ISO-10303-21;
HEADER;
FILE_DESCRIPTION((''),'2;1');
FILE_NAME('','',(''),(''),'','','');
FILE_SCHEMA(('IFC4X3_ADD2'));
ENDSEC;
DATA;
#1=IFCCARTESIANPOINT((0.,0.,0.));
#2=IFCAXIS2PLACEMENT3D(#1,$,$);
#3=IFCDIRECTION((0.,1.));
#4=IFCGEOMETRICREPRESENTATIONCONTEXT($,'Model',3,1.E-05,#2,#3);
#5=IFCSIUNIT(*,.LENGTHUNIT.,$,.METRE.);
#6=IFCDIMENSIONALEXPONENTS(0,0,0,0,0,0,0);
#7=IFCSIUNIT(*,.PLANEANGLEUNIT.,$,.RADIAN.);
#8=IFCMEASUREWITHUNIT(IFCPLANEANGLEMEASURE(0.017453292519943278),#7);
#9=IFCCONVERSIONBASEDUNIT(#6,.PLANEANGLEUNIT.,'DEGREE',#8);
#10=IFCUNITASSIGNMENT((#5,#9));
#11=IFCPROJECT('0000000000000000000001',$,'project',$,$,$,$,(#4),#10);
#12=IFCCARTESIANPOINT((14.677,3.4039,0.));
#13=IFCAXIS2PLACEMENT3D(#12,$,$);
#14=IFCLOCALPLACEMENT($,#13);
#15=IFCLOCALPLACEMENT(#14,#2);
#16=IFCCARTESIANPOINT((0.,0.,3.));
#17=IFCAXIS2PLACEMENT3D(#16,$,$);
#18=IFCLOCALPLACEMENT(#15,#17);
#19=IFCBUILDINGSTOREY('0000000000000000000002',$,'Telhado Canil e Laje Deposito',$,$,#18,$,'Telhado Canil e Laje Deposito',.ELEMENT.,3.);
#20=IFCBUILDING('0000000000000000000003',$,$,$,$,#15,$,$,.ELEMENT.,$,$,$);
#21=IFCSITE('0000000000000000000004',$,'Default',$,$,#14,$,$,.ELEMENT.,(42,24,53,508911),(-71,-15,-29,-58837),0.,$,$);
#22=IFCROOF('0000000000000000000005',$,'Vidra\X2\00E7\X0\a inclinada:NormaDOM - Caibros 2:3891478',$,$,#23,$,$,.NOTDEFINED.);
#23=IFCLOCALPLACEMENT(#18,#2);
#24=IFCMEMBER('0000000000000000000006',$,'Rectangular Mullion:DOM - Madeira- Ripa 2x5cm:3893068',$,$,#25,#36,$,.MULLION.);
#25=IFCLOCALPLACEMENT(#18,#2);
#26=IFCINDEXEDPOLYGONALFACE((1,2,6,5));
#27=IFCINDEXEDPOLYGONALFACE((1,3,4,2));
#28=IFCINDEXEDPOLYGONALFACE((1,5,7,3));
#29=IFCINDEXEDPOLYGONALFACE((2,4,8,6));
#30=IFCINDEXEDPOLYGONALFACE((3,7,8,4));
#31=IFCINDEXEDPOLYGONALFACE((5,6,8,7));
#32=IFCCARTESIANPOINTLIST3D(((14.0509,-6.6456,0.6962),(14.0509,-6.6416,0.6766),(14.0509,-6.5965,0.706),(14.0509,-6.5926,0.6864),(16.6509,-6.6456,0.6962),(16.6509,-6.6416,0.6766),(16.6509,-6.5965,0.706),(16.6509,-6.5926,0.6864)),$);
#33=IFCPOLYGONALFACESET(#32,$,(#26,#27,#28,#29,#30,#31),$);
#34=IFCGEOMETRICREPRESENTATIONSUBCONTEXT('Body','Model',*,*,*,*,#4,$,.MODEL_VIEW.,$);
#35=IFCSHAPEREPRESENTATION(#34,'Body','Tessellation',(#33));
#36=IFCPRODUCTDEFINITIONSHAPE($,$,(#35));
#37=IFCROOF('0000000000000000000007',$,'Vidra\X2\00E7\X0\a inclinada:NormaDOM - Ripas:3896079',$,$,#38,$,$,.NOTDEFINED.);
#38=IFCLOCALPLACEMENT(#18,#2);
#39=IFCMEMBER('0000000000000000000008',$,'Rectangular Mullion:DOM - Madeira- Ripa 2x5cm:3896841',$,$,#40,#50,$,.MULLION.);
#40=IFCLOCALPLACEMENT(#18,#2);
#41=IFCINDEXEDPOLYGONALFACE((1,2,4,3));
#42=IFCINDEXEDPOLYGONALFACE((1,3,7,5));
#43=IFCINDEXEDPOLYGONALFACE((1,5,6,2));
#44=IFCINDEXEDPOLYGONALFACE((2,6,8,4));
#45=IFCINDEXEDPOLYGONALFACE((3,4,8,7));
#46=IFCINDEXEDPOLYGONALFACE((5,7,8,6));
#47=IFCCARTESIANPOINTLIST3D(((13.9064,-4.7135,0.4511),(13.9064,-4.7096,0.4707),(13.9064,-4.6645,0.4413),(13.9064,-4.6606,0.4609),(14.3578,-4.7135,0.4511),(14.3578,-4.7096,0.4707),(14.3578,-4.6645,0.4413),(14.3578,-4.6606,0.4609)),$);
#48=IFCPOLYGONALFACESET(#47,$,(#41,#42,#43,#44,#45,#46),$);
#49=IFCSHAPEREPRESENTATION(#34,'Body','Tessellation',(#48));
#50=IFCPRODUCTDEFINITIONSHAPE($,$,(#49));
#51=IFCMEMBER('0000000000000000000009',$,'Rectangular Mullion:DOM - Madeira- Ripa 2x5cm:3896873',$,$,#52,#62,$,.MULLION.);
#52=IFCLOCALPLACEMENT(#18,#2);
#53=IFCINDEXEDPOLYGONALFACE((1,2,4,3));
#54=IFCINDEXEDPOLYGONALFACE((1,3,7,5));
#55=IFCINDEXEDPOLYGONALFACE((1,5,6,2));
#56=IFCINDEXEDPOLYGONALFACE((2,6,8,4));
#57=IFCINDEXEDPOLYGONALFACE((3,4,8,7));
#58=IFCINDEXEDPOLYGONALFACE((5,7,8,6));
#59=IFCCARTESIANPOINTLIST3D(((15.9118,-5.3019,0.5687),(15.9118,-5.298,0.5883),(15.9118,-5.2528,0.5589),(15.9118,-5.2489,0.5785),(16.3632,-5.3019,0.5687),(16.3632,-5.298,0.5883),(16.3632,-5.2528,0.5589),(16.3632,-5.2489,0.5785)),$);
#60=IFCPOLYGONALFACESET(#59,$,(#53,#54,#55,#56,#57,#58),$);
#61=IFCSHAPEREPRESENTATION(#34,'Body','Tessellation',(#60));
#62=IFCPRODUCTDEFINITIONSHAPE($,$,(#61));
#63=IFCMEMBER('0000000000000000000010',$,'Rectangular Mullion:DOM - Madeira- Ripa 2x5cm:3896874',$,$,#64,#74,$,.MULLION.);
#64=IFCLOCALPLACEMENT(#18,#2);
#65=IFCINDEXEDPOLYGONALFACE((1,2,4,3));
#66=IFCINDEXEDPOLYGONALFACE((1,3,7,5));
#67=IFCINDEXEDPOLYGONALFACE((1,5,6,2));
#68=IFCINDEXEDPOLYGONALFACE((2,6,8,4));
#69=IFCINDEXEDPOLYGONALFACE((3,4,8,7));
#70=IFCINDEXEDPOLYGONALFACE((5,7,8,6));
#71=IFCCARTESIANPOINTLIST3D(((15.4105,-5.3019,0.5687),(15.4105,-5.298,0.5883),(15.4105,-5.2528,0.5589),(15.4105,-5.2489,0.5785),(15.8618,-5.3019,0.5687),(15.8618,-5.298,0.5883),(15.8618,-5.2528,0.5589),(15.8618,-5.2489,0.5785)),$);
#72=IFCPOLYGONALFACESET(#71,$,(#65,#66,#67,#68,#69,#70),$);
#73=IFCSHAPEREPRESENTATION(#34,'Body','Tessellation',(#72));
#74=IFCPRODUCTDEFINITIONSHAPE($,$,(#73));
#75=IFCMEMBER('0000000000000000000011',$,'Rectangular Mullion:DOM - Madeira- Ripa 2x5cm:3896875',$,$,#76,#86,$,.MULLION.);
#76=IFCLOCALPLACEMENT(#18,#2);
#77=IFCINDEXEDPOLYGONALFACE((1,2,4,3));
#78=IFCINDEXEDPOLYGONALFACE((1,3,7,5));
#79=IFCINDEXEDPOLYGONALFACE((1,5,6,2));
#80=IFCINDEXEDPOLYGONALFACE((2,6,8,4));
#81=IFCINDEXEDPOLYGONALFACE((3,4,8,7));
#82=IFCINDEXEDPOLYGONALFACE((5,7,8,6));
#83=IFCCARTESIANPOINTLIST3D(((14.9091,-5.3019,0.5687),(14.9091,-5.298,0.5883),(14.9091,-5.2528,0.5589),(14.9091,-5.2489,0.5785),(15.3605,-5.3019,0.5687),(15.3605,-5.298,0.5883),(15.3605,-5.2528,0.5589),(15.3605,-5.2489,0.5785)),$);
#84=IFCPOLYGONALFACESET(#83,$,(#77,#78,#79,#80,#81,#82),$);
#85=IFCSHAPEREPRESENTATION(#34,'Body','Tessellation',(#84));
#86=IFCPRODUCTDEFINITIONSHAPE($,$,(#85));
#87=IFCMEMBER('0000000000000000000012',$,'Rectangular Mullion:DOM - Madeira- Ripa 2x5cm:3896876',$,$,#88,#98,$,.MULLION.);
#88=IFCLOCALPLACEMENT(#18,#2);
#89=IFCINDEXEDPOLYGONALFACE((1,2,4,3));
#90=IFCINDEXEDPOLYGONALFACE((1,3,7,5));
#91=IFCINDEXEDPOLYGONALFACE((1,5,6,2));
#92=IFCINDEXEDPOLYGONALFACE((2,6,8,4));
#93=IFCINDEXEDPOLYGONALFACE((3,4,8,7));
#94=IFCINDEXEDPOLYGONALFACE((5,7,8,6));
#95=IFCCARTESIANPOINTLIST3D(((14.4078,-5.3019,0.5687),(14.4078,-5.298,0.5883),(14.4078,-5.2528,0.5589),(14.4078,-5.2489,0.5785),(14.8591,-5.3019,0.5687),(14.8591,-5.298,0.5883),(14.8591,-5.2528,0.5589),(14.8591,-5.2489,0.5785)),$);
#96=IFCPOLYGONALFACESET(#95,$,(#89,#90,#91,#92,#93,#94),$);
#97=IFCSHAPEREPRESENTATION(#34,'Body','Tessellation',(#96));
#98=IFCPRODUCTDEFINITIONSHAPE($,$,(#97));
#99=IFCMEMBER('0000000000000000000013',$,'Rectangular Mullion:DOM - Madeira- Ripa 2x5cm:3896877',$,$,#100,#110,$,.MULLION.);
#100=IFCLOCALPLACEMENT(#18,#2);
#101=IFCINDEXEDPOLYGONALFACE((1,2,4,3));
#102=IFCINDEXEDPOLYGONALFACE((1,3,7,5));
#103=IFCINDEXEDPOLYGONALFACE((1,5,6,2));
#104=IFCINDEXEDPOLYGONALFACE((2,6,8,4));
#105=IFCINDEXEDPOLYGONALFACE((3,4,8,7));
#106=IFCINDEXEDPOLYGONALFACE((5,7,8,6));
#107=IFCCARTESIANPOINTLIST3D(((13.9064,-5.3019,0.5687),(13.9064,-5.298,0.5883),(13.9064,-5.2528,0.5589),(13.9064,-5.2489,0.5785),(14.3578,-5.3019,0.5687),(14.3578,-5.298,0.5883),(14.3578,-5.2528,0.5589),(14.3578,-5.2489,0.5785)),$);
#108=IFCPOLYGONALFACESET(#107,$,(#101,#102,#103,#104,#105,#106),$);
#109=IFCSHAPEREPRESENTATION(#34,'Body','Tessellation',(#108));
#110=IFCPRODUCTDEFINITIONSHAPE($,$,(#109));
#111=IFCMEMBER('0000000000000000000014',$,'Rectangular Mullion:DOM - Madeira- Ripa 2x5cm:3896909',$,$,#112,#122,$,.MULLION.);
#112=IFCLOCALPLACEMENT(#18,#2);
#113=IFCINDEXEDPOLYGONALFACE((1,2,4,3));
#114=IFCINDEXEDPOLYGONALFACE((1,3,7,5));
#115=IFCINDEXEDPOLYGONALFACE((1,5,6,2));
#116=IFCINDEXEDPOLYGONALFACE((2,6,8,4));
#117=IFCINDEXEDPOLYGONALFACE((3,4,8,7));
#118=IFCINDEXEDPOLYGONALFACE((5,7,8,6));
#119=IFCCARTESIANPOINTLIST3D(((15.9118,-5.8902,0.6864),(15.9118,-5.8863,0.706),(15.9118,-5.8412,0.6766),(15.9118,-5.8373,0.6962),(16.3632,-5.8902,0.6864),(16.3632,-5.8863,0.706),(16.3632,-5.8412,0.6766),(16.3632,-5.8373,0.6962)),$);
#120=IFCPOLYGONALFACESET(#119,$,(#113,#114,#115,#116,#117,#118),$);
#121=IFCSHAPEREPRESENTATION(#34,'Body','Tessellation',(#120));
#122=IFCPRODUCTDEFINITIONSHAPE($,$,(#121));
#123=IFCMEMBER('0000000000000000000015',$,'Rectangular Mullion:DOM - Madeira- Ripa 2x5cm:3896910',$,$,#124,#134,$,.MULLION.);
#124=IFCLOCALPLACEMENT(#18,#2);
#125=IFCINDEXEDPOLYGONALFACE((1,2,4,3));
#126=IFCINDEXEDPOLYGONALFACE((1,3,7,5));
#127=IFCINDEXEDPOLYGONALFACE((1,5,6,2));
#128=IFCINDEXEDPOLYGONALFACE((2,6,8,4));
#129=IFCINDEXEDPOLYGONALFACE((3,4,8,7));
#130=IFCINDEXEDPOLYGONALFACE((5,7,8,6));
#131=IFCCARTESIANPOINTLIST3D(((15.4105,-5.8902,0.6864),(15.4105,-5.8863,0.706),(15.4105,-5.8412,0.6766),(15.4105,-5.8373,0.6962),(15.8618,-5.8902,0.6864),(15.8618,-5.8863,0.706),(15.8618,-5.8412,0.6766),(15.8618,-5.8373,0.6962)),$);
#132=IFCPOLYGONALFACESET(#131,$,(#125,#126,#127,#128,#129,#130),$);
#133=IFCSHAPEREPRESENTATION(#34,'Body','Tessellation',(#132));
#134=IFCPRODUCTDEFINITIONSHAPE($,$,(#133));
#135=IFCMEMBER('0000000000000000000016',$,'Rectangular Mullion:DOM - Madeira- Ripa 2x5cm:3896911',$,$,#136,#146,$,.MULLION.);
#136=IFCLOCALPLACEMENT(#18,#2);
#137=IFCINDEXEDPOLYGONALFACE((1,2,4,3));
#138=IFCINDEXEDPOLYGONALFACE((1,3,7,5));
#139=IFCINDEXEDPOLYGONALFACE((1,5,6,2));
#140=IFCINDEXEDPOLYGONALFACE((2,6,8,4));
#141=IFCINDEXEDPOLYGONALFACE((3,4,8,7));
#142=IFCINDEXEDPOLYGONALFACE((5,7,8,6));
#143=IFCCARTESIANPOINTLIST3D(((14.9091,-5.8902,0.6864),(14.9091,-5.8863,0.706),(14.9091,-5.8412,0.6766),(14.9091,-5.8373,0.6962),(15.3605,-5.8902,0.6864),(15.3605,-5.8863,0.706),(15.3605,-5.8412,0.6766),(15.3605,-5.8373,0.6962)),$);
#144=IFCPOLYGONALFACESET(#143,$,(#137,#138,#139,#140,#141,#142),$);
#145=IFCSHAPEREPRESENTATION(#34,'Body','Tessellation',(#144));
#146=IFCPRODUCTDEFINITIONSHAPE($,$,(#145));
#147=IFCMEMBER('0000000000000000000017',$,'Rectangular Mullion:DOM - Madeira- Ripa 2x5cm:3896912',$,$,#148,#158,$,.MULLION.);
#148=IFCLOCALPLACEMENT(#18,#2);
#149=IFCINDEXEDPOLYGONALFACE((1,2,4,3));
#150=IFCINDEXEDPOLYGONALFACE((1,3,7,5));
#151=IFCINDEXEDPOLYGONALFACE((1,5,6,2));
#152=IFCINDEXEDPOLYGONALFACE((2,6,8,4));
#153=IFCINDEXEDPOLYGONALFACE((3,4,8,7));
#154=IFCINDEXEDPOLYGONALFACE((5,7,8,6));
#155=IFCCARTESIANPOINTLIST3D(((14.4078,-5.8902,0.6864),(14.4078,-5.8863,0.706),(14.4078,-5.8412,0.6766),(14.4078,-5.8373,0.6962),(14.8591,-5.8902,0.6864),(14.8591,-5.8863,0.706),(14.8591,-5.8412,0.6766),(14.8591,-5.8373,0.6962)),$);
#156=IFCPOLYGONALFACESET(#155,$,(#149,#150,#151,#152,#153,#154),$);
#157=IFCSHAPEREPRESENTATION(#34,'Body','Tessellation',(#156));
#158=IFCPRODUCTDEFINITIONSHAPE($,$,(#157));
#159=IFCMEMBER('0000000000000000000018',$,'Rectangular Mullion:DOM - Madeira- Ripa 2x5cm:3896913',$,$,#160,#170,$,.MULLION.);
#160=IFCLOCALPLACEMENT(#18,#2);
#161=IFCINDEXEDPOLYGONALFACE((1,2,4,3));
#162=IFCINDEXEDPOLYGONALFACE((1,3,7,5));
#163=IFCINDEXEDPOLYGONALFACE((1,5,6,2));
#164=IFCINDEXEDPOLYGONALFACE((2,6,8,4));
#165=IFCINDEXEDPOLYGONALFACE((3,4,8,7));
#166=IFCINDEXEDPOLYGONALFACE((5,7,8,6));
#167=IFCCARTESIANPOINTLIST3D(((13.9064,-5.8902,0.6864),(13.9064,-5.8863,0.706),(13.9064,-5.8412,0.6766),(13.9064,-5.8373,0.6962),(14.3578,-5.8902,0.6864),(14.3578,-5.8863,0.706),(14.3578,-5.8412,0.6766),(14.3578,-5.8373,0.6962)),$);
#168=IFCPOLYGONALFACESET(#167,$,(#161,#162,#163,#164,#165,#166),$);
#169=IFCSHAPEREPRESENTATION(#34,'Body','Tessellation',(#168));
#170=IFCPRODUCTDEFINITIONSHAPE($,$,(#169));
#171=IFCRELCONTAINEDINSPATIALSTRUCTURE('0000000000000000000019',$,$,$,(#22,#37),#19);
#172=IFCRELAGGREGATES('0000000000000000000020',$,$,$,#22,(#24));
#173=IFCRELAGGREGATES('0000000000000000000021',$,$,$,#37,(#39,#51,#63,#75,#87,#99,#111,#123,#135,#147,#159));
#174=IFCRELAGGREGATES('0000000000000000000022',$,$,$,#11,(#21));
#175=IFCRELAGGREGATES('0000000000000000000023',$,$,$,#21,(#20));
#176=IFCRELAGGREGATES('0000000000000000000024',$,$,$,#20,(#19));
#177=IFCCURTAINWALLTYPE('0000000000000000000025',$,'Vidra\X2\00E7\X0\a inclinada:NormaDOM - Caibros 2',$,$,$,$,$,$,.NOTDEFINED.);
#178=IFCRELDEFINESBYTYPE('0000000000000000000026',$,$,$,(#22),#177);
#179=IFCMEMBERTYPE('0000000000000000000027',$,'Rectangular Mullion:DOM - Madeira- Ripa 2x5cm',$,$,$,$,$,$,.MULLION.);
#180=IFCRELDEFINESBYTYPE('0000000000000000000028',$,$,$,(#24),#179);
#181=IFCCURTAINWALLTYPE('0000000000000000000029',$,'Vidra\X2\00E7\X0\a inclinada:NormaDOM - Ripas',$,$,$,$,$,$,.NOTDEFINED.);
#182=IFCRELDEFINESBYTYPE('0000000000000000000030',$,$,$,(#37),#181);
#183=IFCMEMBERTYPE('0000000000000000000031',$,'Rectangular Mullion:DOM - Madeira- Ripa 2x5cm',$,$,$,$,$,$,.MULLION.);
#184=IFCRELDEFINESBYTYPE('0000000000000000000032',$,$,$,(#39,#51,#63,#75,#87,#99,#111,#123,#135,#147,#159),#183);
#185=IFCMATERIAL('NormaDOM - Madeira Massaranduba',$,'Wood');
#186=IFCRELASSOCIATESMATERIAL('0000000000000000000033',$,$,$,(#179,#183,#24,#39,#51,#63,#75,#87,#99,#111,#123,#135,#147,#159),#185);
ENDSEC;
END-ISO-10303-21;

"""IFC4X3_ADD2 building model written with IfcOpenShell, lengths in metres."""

from ifc_helpers import new_model, entity, si_unit, converted_unit, direction, frame, origin, origin_2d_with_axis, place, context, subcontext, project, spatial, rectangle, extrude, source, transform, mapped, material, material_profile, profile_set, profile_usage, type_object, type_shapes, element, aggregate, save


model = new_model("IFC4X3_ADD2")

# Units and contexts
model_context = context("Model", 3, precision=1e-05, world=origin(), true_north=direction((0.0, 1.0)))
body_context = subcontext(model_context, "Body", "Model", "MODEL_VIEW")
ifc_project = project(units=[si_unit("LENGTHUNIT", "METRE"), converted_unit("PLANEANGLEUNIT", "DEGREE", entity("IfcPlaneAngleMeasure", 0.017453292519943278), si_unit("PLANEANGLEUNIT", "RADIAN"), dimensions=[0, 0, 0, 0, 0, 0, 0])], contexts=[model_context])

# Site, building, storey
site_placement = place(None, frame((14.677, 3.4039, 0.0)))
site = spatial("IfcSite", under=ifc_project, at=site_placement, Name="Default", CompositionType="ELEMENT", RefLatitude=(42, 24, 53, 508911), RefLongitude=(-71, -15, -29, -58837), RefElevation=0.0)
building_placement = place(site_placement, origin())
building = spatial("IfcBuilding", under=site, at=building_placement, CompositionType="ELEMENT")
storey_placement = place(building_placement, frame((0.0, 0.0, 3.0)))
storey = spatial("IfcBuildingStorey", under=building, at=storey_placement, Name="Telhado Canil e Laje Deposito", LongName="Telhado Canil e Laje Deposito", CompositionType="ELEMENT", Elevation=3.0)

# Roofs, member
curtain_wall_type_1 = type_object("IfcCurtainWallType", Name="Vidraça inclinada:NormaDOM - Caibros 2", PredefinedType="NOTDEFINED")
roof_1_placement = place(storey_placement, frame((0.0, 0.0, -3.0)))
roof_1 = element("IfcRoof", 1, at=roof_1_placement, inside=storey, type_object=curtain_wall_type_1, Name="Vidraça inclinada:NormaDOM - Caibros 2:3891478", PredefinedType="NOTDEFINED")
ifc_material = material(Name="NormaDOM - Madeira Massaranduba", Category="Wood")
ifc_material_profile_1 = material_profile(ifc_material, rectangle(XDim=0.05, YDim=0.02, at=origin_2d_with_axis()), Name="DOM - Madeira- Ripa 2x5cm")
ifc_profile_set_1 = profile_set([ifc_material_profile_1], Name="DOM - Madeira- Ripa 2x5cm")
ifc_profile_usage_1 = profile_usage(ifc_profile_set_1)
member_type_1 = type_object("IfcMemberType", Name="Rectangular Mullion:DOM - Madeira- Ripa 2x5cm", PredefinedType="MULLION", material=ifc_profile_set_1)
shared_shape_1 = source(origin(), body_context, "Body", "SweptSolid", [
    extrude(rectangle(XDim=0.05, YDim=0.02, at=origin_2d_with_axis()), frame((0.025, 0.01, -2.6), z_axis=(0.0, 0.0, 1.0), x_axis=(-1.0, 0.0, 0.0)), (0.0, 0.0, 1.0), 2.6),
])
type_shapes(member_type_1, [shared_shape_1])
member_1_placement = place(roof_1_placement, frame((14.0509, -6.6456, 3.6962), z_axis=(-1.0, 0.0, 0.0), x_axis=(0.0, 0.980581, 0.196116)))
member_1 = element("IfcMember", 2, at=member_1_placement, type_object=member_type_1, material=ifc_profile_usage_1, Name="Rectangular Mullion:DOM - Madeira- Ripa 2x5cm:3893068", PredefinedType="MULLION", context=body_context, shape_type="MappedRepresentation", body=[
    mapped(shared_shape_1, transform((0.0, 0.0, 0.0), scale=1.0)),
])
curtain_wall_type_2 = type_object("IfcCurtainWallType", Name="Vidraça inclinada:NormaDOM - Ripas", PredefinedType="NOTDEFINED")
roof_2_placement = place(storey_placement, frame((0.0, 0.0, -3.0)))
roof_2 = element("IfcRoof", 3, at=roof_2_placement, inside=storey, type_object=curtain_wall_type_2, Name="Vidraça inclinada:NormaDOM - Ripas:3896079", PredefinedType="NOTDEFINED")

# Members
aggregate(roof_1, [member_1])
member_type_2 = type_object("IfcMemberType", Name="Rectangular Mullion:DOM - Madeira- Ripa 2x5cm", PredefinedType="MULLION", material=ifc_profile_set_1)
shared_shape_2 = source(origin(), body_context, "Body", "SweptSolid", [
    extrude(rectangle(XDim=0.05, YDim=0.02, at=origin_2d_with_axis()), frame((0.025, 0.01, -0.4514), z_axis=(0.0, 0.0, 1.0), x_axis=(-1.0, 0.0, 0.0)), (0.0, 0.0, 1.0), 0.4514),
])
type_shapes(member_type_2, [shared_shape_2])
member_2_placement = place(roof_2_placement, frame((14.3578, -4.6606, 3.4609), z_axis=(1.0, 0.0, 0.0), x_axis=(0.0, -0.980581, 0.196116)))
member_2 = element("IfcMember", 4, at=member_2_placement, type_object=member_type_2, material=ifc_profile_usage_1, Name="Rectangular Mullion:DOM - Madeira- Ripa 2x5cm:3896841", PredefinedType="MULLION", context=body_context, shape_type="MappedRepresentation", body=[
    mapped(shared_shape_2, transform((0.0, 0.0, 0.0), scale=1.0)),
])
member_3_placement = place(roof_2_placement, frame((16.3632, -5.2489, 3.5785), z_axis=(1.0, 0.0, 0.0), x_axis=(0.0, -0.980581, 0.196116)))
member_3 = element("IfcMember", 5, at=member_3_placement, type_object=member_type_2, material=ifc_profile_usage_1, Name="Rectangular Mullion:DOM - Madeira- Ripa 2x5cm:3896873", PredefinedType="MULLION", context=body_context, shape_type="MappedRepresentation", body=[
    mapped(shared_shape_2, transform((0.0, 0.0, 0.0), scale=1.0)),
])
member_4_placement = place(roof_2_placement, frame((15.8618, -5.2489, 3.5785), z_axis=(1.0, 0.0, 0.0), x_axis=(0.0, -0.980581, 0.196116)))
member_4 = element("IfcMember", 6, at=member_4_placement, type_object=member_type_2, material=ifc_profile_usage_1, Name="Rectangular Mullion:DOM - Madeira- Ripa 2x5cm:3896874", PredefinedType="MULLION", context=body_context, shape_type="MappedRepresentation", body=[
    mapped(shared_shape_2, transform((0.0, 0.0, 0.0), scale=1.0)),
])
member_5_placement = place(roof_2_placement, frame((15.3605, -5.2489, 3.5785), z_axis=(1.0, 0.0, 0.0), x_axis=(0.0, -0.980581, 0.196116)))
member_5 = element("IfcMember", 7, at=member_5_placement, type_object=member_type_2, material=ifc_profile_usage_1, Name="Rectangular Mullion:DOM - Madeira- Ripa 2x5cm:3896875", PredefinedType="MULLION", context=body_context, shape_type="MappedRepresentation", body=[
    mapped(shared_shape_2, transform((0.0, 0.0, 0.0), scale=1.0)),
])
member_6_placement = place(roof_2_placement, frame((14.8591, -5.2489, 3.5785), z_axis=(1.0, 0.0, 0.0), x_axis=(0.0, -0.980581, 0.196116)))
member_6 = element("IfcMember", 8, at=member_6_placement, type_object=member_type_2, material=ifc_profile_usage_1, Name="Rectangular Mullion:DOM - Madeira- Ripa 2x5cm:3896876", PredefinedType="MULLION", context=body_context, shape_type="MappedRepresentation", body=[
    mapped(shared_shape_2, transform((0.0, 0.0, 0.0), scale=1.0)),
])
member_7_placement = place(roof_2_placement, frame((14.3578, -5.2489, 3.5785), z_axis=(1.0, 0.0, 0.0), x_axis=(0.0, -0.980581, 0.196116)))
member_7 = element("IfcMember", 9, at=member_7_placement, type_object=member_type_2, material=ifc_profile_usage_1, Name="Rectangular Mullion:DOM - Madeira- Ripa 2x5cm:3896877", PredefinedType="MULLION", context=body_context, shape_type="MappedRepresentation", body=[
    mapped(shared_shape_2, transform((0.0, 0.0, 0.0), scale=1.0)),
])
member_8_placement = place(roof_2_placement, frame((16.3632, -5.8373, 3.6962), z_axis=(1.0, 0.0, 0.0), x_axis=(0.0, -0.980581, 0.196116)))
member_8 = element("IfcMember", 10, at=member_8_placement, type_object=member_type_2, material=ifc_profile_usage_1, Name="Rectangular Mullion:DOM - Madeira- Ripa 2x5cm:3896909", PredefinedType="MULLION", context=body_context, shape_type="MappedRepresentation", body=[
    mapped(shared_shape_2, transform((0.0, 0.0, 0.0), scale=1.0)),
])
member_9_placement = place(roof_2_placement, frame((15.8618, -5.8373, 3.6962), z_axis=(1.0, 0.0, 0.0), x_axis=(0.0, -0.980581, 0.196116)))
member_9 = element("IfcMember", 11, at=member_9_placement, type_object=member_type_2, material=ifc_profile_usage_1, Name="Rectangular Mullion:DOM - Madeira- Ripa 2x5cm:3896910", PredefinedType="MULLION", context=body_context, shape_type="MappedRepresentation", body=[
    mapped(shared_shape_2, transform((0.0, 0.0, 0.0), scale=1.0)),
])
member_10_placement = place(roof_2_placement, frame((15.3605, -5.8373, 3.6962), z_axis=(1.0, 0.0, 0.0), x_axis=(0.0, -0.980581, 0.196116)))
member_10 = element("IfcMember", 12, at=member_10_placement, type_object=member_type_2, material=ifc_profile_usage_1, Name="Rectangular Mullion:DOM - Madeira- Ripa 2x5cm:3896911", PredefinedType="MULLION", context=body_context, shape_type="MappedRepresentation", body=[
    mapped(shared_shape_2, transform((0.0, 0.0, 0.0), scale=1.0)),
])
member_11_placement = place(roof_2_placement, frame((14.8591, -5.8373, 3.6962), z_axis=(1.0, 0.0, 0.0), x_axis=(0.0, -0.980581, 0.196116)))
member_11 = element("IfcMember", 13, at=member_11_placement, type_object=member_type_2, material=ifc_profile_usage_1, Name="Rectangular Mullion:DOM - Madeira- Ripa 2x5cm:3896912", PredefinedType="MULLION", context=body_context, shape_type="MappedRepresentation", body=[
    mapped(shared_shape_2, transform((0.0, 0.0, 0.0), scale=1.0)),
])
member_12_placement = place(roof_2_placement, frame((14.3578, -5.8373, 3.6962), z_axis=(1.0, 0.0, 0.0), x_axis=(0.0, -0.980581, 0.196116)))
member_12 = element("IfcMember", 14, at=member_12_placement, type_object=member_type_2, material=ifc_profile_usage_1, Name="Rectangular Mullion:DOM - Madeira- Ripa 2x5cm:3896913", PredefinedType="MULLION", context=body_context, shape_type="MappedRepresentation", body=[
    mapped(shared_shape_2, transform((0.0, 0.0, 0.0), scale=1.0)),
])
aggregate(roof_2, [member_2, member_3, member_4, member_5, member_6, member_7, member_8, member_9, member_10, member_11, member_12])

save(model, "model.ifc")
